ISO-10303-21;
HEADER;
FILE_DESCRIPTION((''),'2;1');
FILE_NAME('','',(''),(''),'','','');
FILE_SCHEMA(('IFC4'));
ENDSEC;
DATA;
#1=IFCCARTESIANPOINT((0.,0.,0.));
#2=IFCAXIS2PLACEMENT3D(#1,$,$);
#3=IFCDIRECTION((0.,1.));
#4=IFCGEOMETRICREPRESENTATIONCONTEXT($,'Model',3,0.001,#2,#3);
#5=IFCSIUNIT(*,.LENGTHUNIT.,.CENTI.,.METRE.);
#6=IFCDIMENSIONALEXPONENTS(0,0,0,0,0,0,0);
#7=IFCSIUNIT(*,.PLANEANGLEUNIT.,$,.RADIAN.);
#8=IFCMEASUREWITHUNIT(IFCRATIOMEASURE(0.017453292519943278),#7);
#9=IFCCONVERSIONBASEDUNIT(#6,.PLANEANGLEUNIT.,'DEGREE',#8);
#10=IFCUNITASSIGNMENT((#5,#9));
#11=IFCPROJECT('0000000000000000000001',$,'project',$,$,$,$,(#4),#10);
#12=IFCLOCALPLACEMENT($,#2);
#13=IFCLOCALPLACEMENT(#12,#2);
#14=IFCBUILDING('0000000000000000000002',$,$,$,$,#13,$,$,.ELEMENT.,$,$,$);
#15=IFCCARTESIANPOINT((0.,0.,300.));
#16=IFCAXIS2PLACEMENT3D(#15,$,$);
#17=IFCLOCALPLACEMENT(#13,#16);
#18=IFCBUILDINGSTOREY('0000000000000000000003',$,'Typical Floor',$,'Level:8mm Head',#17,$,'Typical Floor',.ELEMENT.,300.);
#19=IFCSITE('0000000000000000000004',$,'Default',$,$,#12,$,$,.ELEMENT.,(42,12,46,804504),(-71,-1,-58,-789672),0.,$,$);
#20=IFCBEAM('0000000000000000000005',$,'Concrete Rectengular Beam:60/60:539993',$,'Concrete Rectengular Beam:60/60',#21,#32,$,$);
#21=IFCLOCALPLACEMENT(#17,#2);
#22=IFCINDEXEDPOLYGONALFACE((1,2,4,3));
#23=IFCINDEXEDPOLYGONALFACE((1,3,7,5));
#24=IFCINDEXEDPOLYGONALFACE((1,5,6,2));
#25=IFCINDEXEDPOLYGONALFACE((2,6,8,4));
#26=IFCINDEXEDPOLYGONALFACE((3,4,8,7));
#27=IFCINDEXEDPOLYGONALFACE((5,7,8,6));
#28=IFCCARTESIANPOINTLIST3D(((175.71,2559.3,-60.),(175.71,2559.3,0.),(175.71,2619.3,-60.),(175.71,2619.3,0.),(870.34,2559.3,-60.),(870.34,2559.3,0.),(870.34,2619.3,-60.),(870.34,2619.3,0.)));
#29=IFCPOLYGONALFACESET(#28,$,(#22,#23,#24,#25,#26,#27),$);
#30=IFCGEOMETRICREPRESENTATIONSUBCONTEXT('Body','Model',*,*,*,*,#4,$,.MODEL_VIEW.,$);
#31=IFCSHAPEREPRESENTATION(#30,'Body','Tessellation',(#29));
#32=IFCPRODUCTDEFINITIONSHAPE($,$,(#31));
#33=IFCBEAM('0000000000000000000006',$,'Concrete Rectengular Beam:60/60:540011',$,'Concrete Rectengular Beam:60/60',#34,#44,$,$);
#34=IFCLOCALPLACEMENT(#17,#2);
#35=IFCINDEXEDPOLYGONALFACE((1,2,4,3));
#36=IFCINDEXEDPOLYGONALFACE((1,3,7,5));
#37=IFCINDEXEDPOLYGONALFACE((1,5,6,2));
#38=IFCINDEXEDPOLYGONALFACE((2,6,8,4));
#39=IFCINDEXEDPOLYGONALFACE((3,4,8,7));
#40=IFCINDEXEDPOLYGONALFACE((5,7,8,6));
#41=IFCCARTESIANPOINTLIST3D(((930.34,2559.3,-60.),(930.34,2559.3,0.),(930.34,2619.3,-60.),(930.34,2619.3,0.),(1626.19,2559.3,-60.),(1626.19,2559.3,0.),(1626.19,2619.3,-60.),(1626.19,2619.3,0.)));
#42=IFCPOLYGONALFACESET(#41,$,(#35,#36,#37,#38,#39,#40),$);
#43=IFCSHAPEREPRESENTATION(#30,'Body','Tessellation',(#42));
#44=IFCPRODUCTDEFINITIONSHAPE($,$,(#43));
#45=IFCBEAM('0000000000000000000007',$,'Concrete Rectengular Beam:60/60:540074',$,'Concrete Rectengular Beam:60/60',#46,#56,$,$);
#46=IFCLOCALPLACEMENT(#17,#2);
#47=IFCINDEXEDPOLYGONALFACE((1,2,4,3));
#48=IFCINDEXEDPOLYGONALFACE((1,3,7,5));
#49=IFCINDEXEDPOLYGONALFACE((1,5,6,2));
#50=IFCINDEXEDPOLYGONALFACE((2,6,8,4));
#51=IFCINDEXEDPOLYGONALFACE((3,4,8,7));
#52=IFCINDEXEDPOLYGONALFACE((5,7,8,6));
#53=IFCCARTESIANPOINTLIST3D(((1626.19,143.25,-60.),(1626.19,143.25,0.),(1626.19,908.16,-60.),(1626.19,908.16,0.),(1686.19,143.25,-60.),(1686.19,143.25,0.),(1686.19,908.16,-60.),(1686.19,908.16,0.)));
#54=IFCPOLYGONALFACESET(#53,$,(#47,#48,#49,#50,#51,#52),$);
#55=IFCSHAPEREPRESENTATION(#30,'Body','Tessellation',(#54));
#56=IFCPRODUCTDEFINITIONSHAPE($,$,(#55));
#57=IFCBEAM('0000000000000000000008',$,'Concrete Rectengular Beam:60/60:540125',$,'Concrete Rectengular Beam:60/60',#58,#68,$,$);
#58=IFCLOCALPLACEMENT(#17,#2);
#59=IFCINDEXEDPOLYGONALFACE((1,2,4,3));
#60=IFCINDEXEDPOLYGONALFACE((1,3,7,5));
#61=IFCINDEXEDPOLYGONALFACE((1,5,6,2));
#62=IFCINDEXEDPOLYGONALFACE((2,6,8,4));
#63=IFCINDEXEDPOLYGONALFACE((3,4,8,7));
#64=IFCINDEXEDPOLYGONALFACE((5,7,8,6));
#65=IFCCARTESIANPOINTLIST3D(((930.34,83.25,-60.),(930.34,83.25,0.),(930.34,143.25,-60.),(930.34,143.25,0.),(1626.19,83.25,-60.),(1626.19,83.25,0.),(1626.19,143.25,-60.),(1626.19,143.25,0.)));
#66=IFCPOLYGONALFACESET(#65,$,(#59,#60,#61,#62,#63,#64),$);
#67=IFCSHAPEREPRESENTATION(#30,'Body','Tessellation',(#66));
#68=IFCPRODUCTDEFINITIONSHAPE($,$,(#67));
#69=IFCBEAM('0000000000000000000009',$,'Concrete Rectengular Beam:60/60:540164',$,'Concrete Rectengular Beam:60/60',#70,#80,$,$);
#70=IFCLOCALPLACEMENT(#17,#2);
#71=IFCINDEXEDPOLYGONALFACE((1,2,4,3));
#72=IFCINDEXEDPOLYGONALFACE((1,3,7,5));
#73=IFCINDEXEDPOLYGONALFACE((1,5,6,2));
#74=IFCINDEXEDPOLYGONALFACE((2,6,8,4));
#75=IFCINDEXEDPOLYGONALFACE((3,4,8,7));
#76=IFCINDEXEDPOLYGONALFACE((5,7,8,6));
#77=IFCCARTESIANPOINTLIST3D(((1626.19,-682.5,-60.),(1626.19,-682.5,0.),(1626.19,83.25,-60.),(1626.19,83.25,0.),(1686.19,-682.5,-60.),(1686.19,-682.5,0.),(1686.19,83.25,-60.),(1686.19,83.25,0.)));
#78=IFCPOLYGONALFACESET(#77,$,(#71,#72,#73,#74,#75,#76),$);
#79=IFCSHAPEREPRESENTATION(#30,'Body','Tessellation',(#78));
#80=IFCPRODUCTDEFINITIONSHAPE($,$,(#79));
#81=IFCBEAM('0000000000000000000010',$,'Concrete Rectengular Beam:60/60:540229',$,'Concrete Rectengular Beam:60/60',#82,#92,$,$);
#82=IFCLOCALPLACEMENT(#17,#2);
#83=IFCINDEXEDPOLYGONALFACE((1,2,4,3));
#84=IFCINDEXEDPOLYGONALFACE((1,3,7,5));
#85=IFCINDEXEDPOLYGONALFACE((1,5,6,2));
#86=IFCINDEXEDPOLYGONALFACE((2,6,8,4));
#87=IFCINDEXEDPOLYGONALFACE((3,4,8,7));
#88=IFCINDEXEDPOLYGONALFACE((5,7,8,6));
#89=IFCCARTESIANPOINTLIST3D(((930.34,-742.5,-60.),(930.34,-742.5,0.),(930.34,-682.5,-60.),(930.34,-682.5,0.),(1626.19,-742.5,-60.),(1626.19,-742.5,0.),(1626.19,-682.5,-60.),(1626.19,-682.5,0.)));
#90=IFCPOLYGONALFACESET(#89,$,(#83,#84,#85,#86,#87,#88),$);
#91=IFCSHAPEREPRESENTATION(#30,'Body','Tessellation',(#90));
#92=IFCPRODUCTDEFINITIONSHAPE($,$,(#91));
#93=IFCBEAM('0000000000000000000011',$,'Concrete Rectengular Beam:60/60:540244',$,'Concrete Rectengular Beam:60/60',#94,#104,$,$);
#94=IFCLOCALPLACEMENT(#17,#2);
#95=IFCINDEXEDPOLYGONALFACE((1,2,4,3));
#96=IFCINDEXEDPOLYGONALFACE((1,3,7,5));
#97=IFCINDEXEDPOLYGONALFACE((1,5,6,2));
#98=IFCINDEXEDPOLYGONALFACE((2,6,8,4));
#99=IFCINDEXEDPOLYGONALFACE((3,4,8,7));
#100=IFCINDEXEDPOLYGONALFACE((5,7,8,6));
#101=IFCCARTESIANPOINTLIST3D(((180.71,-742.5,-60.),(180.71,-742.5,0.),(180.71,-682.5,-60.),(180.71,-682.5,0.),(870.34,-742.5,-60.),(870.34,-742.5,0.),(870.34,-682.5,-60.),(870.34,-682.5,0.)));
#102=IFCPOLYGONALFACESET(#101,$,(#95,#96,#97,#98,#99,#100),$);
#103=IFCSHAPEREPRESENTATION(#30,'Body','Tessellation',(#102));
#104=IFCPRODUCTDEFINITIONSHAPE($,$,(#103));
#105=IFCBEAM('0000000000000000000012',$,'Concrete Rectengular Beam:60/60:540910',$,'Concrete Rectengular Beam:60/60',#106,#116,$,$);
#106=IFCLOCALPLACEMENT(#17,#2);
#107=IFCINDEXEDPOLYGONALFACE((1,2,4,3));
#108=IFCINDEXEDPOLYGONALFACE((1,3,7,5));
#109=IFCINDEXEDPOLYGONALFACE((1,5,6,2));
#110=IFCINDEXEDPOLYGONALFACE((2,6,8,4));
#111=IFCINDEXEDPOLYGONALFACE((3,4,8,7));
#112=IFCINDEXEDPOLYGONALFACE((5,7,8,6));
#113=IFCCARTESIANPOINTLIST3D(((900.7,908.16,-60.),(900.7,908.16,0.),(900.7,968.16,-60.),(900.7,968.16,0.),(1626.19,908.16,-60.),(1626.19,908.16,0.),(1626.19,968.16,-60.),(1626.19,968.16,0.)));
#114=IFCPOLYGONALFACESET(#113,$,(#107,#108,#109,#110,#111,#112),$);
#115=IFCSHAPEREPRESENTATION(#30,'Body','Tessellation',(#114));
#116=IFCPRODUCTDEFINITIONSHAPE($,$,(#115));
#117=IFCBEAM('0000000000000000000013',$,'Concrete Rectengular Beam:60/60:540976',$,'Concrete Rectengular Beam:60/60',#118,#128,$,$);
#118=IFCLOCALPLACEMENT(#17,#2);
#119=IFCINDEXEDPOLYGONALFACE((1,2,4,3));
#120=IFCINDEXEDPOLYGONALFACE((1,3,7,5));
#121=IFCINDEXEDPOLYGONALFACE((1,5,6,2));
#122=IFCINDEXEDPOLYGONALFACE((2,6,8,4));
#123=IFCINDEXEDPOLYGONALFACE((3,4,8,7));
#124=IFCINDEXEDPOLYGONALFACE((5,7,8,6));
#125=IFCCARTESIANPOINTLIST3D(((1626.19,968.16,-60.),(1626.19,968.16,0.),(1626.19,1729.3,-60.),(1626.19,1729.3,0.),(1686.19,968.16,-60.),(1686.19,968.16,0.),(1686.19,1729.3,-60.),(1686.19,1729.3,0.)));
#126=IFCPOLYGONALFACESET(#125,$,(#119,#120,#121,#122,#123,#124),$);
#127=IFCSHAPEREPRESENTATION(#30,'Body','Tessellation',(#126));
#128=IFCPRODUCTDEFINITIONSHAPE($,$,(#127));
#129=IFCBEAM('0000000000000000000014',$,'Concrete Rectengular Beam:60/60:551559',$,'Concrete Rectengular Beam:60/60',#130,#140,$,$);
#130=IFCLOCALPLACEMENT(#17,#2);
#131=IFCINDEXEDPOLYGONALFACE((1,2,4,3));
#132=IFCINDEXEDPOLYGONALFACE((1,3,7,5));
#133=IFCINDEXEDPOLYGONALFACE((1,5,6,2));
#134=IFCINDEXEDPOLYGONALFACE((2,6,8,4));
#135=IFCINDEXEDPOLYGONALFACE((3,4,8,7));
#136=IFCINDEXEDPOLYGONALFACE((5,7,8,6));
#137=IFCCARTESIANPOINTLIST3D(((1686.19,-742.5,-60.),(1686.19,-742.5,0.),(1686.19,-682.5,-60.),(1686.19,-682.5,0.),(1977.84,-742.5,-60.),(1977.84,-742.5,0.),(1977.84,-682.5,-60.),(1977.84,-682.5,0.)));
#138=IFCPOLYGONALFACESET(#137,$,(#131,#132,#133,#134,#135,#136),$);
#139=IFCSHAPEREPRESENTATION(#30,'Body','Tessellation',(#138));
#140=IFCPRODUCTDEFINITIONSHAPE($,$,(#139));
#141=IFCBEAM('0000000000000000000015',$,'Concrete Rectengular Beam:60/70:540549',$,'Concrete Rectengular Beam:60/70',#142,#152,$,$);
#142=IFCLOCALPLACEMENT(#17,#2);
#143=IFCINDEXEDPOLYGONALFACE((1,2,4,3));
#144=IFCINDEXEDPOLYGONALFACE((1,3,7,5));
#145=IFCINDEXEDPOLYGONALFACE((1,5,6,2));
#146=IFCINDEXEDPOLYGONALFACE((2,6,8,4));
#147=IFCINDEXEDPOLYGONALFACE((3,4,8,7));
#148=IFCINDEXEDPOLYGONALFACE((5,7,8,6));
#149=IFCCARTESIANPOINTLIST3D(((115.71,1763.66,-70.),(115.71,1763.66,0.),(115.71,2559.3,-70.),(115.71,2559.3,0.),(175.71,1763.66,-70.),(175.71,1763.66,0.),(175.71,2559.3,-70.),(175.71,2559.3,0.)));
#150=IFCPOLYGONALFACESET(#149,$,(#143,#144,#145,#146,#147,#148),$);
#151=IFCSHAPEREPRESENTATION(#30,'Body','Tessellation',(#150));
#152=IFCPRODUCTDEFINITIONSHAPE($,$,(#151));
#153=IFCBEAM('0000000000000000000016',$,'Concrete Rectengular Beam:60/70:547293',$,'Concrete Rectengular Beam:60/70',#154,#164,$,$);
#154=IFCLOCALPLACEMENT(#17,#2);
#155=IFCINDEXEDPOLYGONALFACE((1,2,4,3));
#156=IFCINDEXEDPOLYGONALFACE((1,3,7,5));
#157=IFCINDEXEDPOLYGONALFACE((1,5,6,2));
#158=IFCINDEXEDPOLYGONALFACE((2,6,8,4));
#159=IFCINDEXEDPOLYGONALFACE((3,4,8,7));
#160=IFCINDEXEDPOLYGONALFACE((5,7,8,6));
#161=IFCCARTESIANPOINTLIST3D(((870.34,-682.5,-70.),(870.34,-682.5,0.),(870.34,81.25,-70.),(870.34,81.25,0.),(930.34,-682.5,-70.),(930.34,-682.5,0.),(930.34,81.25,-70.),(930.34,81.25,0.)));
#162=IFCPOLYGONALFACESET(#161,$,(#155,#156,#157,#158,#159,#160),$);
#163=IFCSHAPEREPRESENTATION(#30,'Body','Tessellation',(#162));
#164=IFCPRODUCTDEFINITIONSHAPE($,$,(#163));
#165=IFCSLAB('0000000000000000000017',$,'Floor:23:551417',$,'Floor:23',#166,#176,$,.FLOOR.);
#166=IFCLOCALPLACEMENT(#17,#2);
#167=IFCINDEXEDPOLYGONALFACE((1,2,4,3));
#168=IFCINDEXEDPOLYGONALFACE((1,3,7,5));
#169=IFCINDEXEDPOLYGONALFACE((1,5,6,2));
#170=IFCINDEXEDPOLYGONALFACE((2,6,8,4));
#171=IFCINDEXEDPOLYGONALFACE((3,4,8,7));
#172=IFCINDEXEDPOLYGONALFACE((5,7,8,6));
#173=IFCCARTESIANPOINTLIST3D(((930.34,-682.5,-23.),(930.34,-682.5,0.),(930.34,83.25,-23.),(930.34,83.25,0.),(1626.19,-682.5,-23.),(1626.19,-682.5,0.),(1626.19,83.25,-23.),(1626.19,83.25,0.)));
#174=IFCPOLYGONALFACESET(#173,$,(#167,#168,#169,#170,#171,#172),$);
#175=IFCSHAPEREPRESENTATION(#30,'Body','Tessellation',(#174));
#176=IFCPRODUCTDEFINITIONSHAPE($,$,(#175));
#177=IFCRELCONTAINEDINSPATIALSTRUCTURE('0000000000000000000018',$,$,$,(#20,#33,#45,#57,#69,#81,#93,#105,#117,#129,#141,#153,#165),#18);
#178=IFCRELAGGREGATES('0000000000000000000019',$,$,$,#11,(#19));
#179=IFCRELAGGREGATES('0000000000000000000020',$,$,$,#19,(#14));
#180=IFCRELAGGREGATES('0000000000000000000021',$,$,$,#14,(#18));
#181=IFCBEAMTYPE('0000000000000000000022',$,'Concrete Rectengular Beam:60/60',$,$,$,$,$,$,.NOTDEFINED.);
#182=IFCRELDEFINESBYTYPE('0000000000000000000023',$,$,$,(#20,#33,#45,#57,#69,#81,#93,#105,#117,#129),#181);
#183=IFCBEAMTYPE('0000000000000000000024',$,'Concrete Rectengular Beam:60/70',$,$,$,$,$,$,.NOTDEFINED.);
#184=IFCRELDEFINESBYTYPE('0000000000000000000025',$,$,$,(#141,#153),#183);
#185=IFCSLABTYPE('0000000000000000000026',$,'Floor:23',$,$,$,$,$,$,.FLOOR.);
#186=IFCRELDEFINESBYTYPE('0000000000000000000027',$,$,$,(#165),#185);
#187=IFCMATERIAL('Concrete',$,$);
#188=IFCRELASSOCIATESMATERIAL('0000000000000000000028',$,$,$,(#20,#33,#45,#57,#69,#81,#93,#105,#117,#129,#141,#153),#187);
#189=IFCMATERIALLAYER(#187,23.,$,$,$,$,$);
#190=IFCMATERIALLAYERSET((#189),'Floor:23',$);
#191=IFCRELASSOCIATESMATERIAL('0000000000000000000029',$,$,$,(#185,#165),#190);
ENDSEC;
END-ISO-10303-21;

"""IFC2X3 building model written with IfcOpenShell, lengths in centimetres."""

from ifc_helpers import new_model, entity, si_unit, converted_unit, direction, frame, frame_2d, origin, origin_2d_with_axis, place, context, subcontext, project, spatial, rectangle, extrude, material, layer, layer_set, layer_usage, type_object, element, save


model = new_model("IFC2X3")

# Units and contexts
model_context = context("Model", 3, precision=0.001, world=origin(), true_north=direction((0.0, 1.0)))
body_context = subcontext(model_context, "Body", "Model", "MODEL_VIEW")
ifc_project = project(units=[si_unit("LENGTHUNIT", "METRE", prefix="CENTI"), converted_unit("PLANEANGLEUNIT", "DEGREE", entity("IfcRatioMeasure", 0.017453292519943278), si_unit("PLANEANGLEUNIT", "RADIAN"), dimensions=[0, 0, 0, 0, 0, 0, 0])], contexts=[model_context])

# Site, building, storey
site_placement = place(None, origin())
site = spatial("IfcSite", under=ifc_project, at=site_placement, Name="Default", CompositionType="ELEMENT", RefLatitude=(42, 12, 46, 804504), RefLongitude=(-71, -1, -58, -789672), RefElevation=0.0)
building_placement = place(site_placement, origin())
building = spatial("IfcBuilding", under=site, at=building_placement, CompositionType="ELEMENT")
storey_placement = place(building_placement, frame((0.0, 0.0, 300.0)))
storey = spatial("IfcBuildingStorey", under=building, at=storey_placement, Name="Typical Floor", ObjectType="Level:8mm Head", LongName="Typical Floor", CompositionType="ELEMENT", Elevation=300.0)

# Beams
ifc_material = material(Name="Concrete")
beam_type_1 = type_object("IfcBeamType", Name="Concrete Rectengular Beam:60/60", PredefinedType="NOTDEFINED")
beam_1_placement = place(storey_placement, frame((145.71, 2589.3, 0.0)))
element("IfcBeam", 1, at=beam_1_placement, inside=storey, type_object=beam_type_1, material=ifc_material, Name="Concrete Rectengular Beam:60/60:539993", ObjectType="Concrete Rectengular Beam:60/60", context=body_context, shape_type="SweptSolid", body=[
    extrude(rectangle(XDim=60.0, YDim=60.0, at=frame_2d((0.0, 0.0), x_axis=(1.0, 0.0))), frame((30.0, 0.0, -30.0), z_axis=(1.0, 0.0, 0.0), x_axis=(0.0, 0.0, -1.0)), (0.0, 0.0, 1.0), 694.63),
])
beam_2_placement = place(storey_placement, frame((900.34, 2589.3, 0.0)))
element("IfcBeam", 2, at=beam_2_placement, inside=storey, type_object=beam_type_1, material=ifc_material, Name="Concrete Rectengular Beam:60/60:540011", ObjectType="Concrete Rectengular Beam:60/60", context=body_context, shape_type="SweptSolid", body=[
    extrude(rectangle(XDim=60.0, YDim=60.0, at=frame_2d((0.0, 0.0), x_axis=(1.0, 0.0))), frame((30.0, 0.0, -30.0), z_axis=(1.0, 0.0, 0.0), x_axis=(0.0, 0.0, -1.0)), (0.0, 0.0, 1.0), 695.85),
])
beam_3_placement = place(storey_placement, frame((1656.19, 938.16, 0.0), z_axis=(0.0, 0.0, 1.0), x_axis=(0.0, -1.0, 0.0)))
element("IfcBeam", 3, at=beam_3_placement, inside=storey, type_object=beam_type_1, material=ifc_material, Name="Concrete Rectengular Beam:60/60:540074", ObjectType="Concrete Rectengular Beam:60/60", context=body_context, shape_type="SweptSolid", body=[
    extrude(rectangle(XDim=60.0, YDim=60.0, at=frame_2d((0.0, 0.0), x_axis=(1.0, 0.0))), frame((30.0, 0.0, -30.0), z_axis=(1.0, 0.0, 0.0), x_axis=(0.0, 0.0, -1.0)), (0.0, 0.0, 1.0), 764.91),
])
beam_4_placement = place(storey_placement, frame((1656.19, 113.25, 0.0), z_axis=(0.0, 0.0, 1.0), x_axis=(-1.0, 0.0, 0.0)))
element("IfcBeam", 4, at=beam_4_placement, inside=storey, type_object=beam_type_1, material=ifc_material, Name="Concrete Rectengular Beam:60/60:540125", ObjectType="Concrete Rectengular Beam:60/60", context=body_context, shape_type="SweptSolid", body=[
    extrude(rectangle(XDim=60.0, YDim=60.0, at=frame_2d((0.0, 0.0), x_axis=(1.0, 0.0))), frame((30.0, 0.0, -30.0), z_axis=(1.0, 0.0, 0.0), x_axis=(0.0, 0.0, -1.0)), (0.0, 0.0, 1.0), 695.85),
])
beam_5_placement = place(storey_placement, frame((1656.19, 113.25, 0.0), z_axis=(0.0, 0.0, 1.0), x_axis=(0.0, -1.0, 0.0)))
element("IfcBeam", 5, at=beam_5_placement, inside=storey, type_object=beam_type_1, material=ifc_material, Name="Concrete Rectengular Beam:60/60:540164", ObjectType="Concrete Rectengular Beam:60/60", context=body_context, shape_type="SweptSolid", body=[
    extrude(rectangle(XDim=60.0, YDim=60.0, at=frame_2d((0.0, 0.0), x_axis=(1.0, 0.0))), frame((30.0, 0.0, -30.0), z_axis=(1.0, 0.0, 0.0), x_axis=(0.0, 0.0, -1.0)), (0.0, 0.0, 1.0), 765.75),
])
beam_6_placement = place(storey_placement, frame((1656.19, -712.5, 0.0), z_axis=(0.0, 0.0, 1.0), x_axis=(-1.0, 0.0, 0.0)))
element("IfcBeam", 6, at=beam_6_placement, inside=storey, type_object=beam_type_1, material=ifc_material, Name="Concrete Rectengular Beam:60/60:540229", ObjectType="Concrete Rectengular Beam:60/60", context=body_context, shape_type="SweptSolid", body=[
    extrude(rectangle(XDim=60.0, YDim=60.0, at=frame_2d((0.0, 0.0), x_axis=(1.0, 0.0))), frame((30.0, 0.0, -30.0), z_axis=(1.0, 0.0, 0.0), x_axis=(0.0, 0.0, -1.0)), (0.0, 0.0, 1.0), 695.85),
])
beam_7_placement = place(storey_placement, frame((900.34, -712.5, 0.0), z_axis=(0.0, 0.0, 1.0), x_axis=(-1.0, 0.0, 0.0)))
element("IfcBeam", 7, at=beam_7_placement, inside=storey, type_object=beam_type_1, material=ifc_material, Name="Concrete Rectengular Beam:60/60:540244", ObjectType="Concrete Rectengular Beam:60/60", context=body_context, shape_type="SweptSolid", body=[
    extrude(rectangle(XDim=60.0, YDim=60.0, at=frame_2d((0.0, 0.0), x_axis=(1.0, 0.0))), frame((30.0, 0.0, -30.0), z_axis=(1.0, 0.0, 0.0), x_axis=(0.0, 0.0, -1.0)), (0.0, 0.0, 1.0), 689.63),
])
beam_8_placement = place(storey_placement, frame((1656.19, 938.16, 0.0), z_axis=(0.0, 0.0, 1.0), x_axis=(-1.0, 0.0, 0.0)))
element("IfcBeam", 8, at=beam_8_placement, inside=storey, type_object=beam_type_1, material=ifc_material, Name="Concrete Rectengular Beam:60/60:540910", ObjectType="Concrete Rectengular Beam:60/60", context=body_context, shape_type="SweptSolid", body=[
    extrude(rectangle(XDim=60.0, YDim=60.0, at=frame_2d((0.0, 0.0), x_axis=(1.0, 0.0))), frame((30.0, 0.0, -30.0), z_axis=(1.0, 0.0, 0.0), x_axis=(0.0, 0.0, -1.0)), (0.0, 0.0, 1.0), 725.49),
])
beam_9_placement = place(storey_placement, frame((1656.19, 938.16, 0.0), z_axis=(0.0, 0.0, 1.0), x_axis=(0.0, 1.0, 0.0)))
element("IfcBeam", 9, at=beam_9_placement, inside=storey, type_object=beam_type_1, material=ifc_material, Name="Concrete Rectengular Beam:60/60:540976", ObjectType="Concrete Rectengular Beam:60/60", context=body_context, shape_type="SweptSolid", body=[
    extrude(rectangle(XDim=60.0, YDim=60.0, at=frame_2d((0.0, 0.0), x_axis=(1.0, 0.0))), frame((30.0, 0.0, -30.0), z_axis=(1.0, 0.0, 0.0), x_axis=(0.0, 0.0, -1.0)), (0.0, 0.0, 1.0), 761.14),
])
beam_10_placement = place(storey_placement, frame((2007.83, -712.5, 0.0), z_axis=(0.0, 0.0, 1.0), x_axis=(-1.0, 0.0, 0.0)))
element("IfcBeam", 10, at=beam_10_placement, inside=storey, type_object=beam_type_1, material=ifc_material, Name="Concrete Rectengular Beam:60/60:551559", ObjectType="Concrete Rectengular Beam:60/60", context=body_context, shape_type="SweptSolid", body=[
    extrude(rectangle(XDim=60.0, YDim=60.0, at=frame_2d((0.0, 0.0), x_axis=(1.0, 0.0))), frame((29.99, 0.0, -30.0), z_axis=(1.0, 0.0, 0.0), x_axis=(0.0, 0.0, -1.0)), (0.0, 0.0, 1.0), 291.65),
])
beam_type_2 = type_object("IfcBeamType", Name="Concrete Rectengular Beam:60/70", PredefinedType="NOTDEFINED")
beam_11_placement = place(storey_placement, frame((145.71, 2589.3, 0.0), z_axis=(0.0, 0.0, 1.0), x_axis=(0.0, -1.0, 0.0)))
element("IfcBeam", 11, at=beam_11_placement, inside=storey, type_object=beam_type_2, material=ifc_material, Name="Concrete Rectengular Beam:60/70:540549", ObjectType="Concrete Rectengular Beam:60/70", context=body_context, shape_type="SweptSolid", body=[
    extrude(rectangle(XDim=70.0, YDim=60.0, at=origin_2d_with_axis()), frame((30.0, 0.0, -35.0), z_axis=(1.0, 0.0, 0.0), x_axis=(0.0, 0.0, -1.0)), (0.0, 0.0, 1.0), 795.63),
])
beam_12_placement = place(storey_placement, frame((900.34, -712.5, 0.0), z_axis=(0.0, 0.0, 1.0), x_axis=(0.0, 1.0, 0.0)))
element("IfcBeam", 12, at=beam_12_placement, inside=storey, type_object=beam_type_2, material=ifc_material, Name="Concrete Rectengular Beam:60/70:547293", ObjectType="Concrete Rectengular Beam:60/70", context=body_context, shape_type="SweptSolid", body=[
    extrude(rectangle(XDim=70.0, YDim=60.0, at=origin_2d_with_axis()), frame((30.0, 0.0, -35.0), z_axis=(1.0, 0.0, 0.0), x_axis=(0.0, 0.0, -1.0)), (0.0, 0.0, 1.0), 763.75),
])

# Slab
ifc_layer = layer(ifc_material, 23.0)
ifc_layer_set = layer_set([ifc_layer], Name="Floor:23")
ifc_layer_usage_1 = layer_usage(ifc_layer_set, "AXIS3", "POSITIVE", 0.0)
slab_type_1 = type_object("IfcSlabType", Name="Floor:23", PredefinedType="FLOOR", material=ifc_layer_set)
slab_1_placement = place(storey_placement, origin())
element("IfcSlab", 13, at=slab_1_placement, inside=storey, type_object=slab_type_1, material=ifc_layer_usage_1, Name="Floor:23:551417", ObjectType="Floor:23", PredefinedType="FLOOR", context=body_context, shape_type="SweptSolid", body=[
    extrude(rectangle(XDim=765.75, YDim=695.85, at=origin_2d_with_axis()), frame((1278.26, -299.63, 0.0), z_axis=(0.0, 0.0, -1.0), x_axis=(0.0, 1.0, 0.0)), (0.0, 0.0, 1.0), 23.0),
])

save(model, "model.ifc")
